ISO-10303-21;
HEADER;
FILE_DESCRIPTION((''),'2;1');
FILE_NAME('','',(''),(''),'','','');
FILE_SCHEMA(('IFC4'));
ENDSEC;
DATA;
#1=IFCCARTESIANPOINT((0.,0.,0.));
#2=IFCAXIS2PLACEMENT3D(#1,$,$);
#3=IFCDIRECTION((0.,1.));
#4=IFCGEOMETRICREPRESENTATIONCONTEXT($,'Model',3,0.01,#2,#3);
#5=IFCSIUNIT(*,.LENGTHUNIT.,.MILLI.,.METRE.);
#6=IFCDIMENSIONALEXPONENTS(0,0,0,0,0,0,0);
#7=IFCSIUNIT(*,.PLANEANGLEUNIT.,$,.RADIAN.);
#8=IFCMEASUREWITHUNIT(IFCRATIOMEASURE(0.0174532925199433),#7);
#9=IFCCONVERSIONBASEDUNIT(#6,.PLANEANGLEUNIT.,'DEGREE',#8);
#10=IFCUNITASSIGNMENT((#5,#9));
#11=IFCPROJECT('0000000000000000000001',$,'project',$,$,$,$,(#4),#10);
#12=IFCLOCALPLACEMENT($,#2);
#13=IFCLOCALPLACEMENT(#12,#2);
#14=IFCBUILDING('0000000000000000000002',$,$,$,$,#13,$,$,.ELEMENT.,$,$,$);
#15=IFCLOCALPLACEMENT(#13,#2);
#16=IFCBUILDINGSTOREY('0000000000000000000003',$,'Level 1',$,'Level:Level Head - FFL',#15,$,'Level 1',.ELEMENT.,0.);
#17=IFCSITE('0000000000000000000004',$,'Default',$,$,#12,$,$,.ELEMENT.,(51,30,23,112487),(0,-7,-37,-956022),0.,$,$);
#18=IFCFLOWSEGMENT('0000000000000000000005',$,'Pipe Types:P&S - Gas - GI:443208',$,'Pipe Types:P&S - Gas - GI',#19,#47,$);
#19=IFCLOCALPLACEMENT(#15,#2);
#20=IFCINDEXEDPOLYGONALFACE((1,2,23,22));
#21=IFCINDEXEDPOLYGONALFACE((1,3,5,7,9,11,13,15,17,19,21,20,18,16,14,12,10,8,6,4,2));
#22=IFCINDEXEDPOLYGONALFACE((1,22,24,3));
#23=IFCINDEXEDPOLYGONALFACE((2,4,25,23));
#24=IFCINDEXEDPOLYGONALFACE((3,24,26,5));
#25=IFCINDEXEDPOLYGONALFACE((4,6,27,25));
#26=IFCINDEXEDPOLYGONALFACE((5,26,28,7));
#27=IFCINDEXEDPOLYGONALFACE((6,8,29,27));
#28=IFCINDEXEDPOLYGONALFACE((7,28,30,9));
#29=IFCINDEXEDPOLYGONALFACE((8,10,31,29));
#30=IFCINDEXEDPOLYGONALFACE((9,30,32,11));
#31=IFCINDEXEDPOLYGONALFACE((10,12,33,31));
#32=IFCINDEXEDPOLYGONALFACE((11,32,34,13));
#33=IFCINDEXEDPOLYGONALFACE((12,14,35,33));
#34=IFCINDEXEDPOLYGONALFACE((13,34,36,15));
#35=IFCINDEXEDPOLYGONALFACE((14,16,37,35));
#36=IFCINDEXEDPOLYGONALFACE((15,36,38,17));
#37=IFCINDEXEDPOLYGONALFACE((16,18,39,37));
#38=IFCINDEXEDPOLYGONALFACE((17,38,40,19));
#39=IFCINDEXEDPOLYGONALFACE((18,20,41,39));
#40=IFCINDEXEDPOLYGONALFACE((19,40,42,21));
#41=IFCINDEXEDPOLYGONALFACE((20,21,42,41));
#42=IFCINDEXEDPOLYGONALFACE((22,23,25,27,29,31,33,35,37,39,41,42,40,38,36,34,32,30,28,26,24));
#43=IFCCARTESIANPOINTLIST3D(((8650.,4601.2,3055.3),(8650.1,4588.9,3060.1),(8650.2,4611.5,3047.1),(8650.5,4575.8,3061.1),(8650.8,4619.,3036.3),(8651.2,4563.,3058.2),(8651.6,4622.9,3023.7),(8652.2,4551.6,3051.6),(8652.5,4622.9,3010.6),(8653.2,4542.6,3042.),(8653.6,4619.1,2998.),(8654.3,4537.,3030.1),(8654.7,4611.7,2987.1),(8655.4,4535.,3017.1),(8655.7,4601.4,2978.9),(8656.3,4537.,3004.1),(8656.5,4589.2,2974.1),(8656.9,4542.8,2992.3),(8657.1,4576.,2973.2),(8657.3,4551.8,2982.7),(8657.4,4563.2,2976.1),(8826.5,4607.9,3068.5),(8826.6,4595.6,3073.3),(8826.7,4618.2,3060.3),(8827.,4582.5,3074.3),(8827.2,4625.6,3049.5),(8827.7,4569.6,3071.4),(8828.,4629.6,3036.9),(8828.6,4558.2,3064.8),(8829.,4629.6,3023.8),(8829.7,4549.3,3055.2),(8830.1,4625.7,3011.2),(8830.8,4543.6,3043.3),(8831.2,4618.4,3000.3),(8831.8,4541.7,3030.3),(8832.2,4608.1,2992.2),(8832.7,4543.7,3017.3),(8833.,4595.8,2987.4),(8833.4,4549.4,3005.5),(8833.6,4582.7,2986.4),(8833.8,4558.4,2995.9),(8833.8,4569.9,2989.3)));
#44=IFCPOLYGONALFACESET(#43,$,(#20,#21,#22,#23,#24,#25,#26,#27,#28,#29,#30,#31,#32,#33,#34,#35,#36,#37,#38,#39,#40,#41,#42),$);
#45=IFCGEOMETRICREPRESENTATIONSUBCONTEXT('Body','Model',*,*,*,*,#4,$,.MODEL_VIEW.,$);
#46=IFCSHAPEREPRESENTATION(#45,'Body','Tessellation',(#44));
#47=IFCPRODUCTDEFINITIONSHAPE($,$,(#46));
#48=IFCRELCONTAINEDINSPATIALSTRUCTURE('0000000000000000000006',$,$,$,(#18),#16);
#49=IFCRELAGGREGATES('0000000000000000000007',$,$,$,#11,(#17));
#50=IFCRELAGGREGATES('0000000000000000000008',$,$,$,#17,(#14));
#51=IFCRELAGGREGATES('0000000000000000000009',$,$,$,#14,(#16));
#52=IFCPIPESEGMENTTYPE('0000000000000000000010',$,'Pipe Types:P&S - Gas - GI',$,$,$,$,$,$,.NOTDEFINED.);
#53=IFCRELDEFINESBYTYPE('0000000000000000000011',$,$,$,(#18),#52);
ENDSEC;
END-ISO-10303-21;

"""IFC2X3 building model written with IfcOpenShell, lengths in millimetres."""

from ifc_helpers import new_model, entity, si_unit, converted_unit, direction, frame, origin, origin_2d_with_axis, place, context, subcontext, project, spatial, circle, extrude, type_object, element, save


model = new_model("IFC2X3")

# Units and contexts
model_context = context("Model", 3, precision=0.01, world=origin(), true_north=direction((0.0, 1.0)))
body_context = subcontext(model_context, "Body", "Model", "MODEL_VIEW")
ifc_project = project(units=[si_unit("LENGTHUNIT", "METRE", prefix="MILLI"), converted_unit("PLANEANGLEUNIT", "DEGREE", entity("IfcRatioMeasure", 0.0174532925199433), si_unit("PLANEANGLEUNIT", "RADIAN"), dimensions=[0, 0, 0, 0, 0, 0, 0])], contexts=[model_context])

# Site, building, storey
site_placement = place(None, origin())
site = spatial("IfcSite", under=ifc_project, at=site_placement, Name="Default", CompositionType="ELEMENT", RefLatitude=(51, 30, 23, 112487), RefLongitude=(0, -7, -37, -956022), RefElevation=0.0)
building_placement = place(site_placement, origin())
building = spatial("IfcBuilding", under=site, at=building_placement, CompositionType="ELEMENT")
storey_placement = place(building_placement, origin())
storey = spatial("IfcBuildingStorey", under=building, at=storey_placement, Name="Level 1", ObjectType="Level:Level Head - FFL", LongName="Level 1", CompositionType="ELEMENT", Elevation=0.0)

# Flow segment
pipe_segment_type = type_object("IfcPipeSegmentType", Name="Pipe Types:P&S - Gas - GI", PredefinedType="NOTDEFINED")
flow_segment_1_placement = place(storey_placement, origin())
element("IfcFlowSegment", 1, at=flow_segment_1_placement, inside=storey, type_object=pipe_segment_type, Name="Pipe Types:P&S - Gas - GI:443208", ObjectType="Pipe Types:P&S - Gas - GI", context=body_context, shape_type="SweptSolid", body=[
    extrude(circle(Radius=44.2, at=origin_2d_with_axis()), frame((8653.7, 4579.2, 3017.1), z_axis=(0.996502, 0.037589, 0.074634), x_axis=(0.037694, -0.999289, 0.0)), (0.0, 0.0, 1.0), 177.1),
])

save(model, "model.ifc")
